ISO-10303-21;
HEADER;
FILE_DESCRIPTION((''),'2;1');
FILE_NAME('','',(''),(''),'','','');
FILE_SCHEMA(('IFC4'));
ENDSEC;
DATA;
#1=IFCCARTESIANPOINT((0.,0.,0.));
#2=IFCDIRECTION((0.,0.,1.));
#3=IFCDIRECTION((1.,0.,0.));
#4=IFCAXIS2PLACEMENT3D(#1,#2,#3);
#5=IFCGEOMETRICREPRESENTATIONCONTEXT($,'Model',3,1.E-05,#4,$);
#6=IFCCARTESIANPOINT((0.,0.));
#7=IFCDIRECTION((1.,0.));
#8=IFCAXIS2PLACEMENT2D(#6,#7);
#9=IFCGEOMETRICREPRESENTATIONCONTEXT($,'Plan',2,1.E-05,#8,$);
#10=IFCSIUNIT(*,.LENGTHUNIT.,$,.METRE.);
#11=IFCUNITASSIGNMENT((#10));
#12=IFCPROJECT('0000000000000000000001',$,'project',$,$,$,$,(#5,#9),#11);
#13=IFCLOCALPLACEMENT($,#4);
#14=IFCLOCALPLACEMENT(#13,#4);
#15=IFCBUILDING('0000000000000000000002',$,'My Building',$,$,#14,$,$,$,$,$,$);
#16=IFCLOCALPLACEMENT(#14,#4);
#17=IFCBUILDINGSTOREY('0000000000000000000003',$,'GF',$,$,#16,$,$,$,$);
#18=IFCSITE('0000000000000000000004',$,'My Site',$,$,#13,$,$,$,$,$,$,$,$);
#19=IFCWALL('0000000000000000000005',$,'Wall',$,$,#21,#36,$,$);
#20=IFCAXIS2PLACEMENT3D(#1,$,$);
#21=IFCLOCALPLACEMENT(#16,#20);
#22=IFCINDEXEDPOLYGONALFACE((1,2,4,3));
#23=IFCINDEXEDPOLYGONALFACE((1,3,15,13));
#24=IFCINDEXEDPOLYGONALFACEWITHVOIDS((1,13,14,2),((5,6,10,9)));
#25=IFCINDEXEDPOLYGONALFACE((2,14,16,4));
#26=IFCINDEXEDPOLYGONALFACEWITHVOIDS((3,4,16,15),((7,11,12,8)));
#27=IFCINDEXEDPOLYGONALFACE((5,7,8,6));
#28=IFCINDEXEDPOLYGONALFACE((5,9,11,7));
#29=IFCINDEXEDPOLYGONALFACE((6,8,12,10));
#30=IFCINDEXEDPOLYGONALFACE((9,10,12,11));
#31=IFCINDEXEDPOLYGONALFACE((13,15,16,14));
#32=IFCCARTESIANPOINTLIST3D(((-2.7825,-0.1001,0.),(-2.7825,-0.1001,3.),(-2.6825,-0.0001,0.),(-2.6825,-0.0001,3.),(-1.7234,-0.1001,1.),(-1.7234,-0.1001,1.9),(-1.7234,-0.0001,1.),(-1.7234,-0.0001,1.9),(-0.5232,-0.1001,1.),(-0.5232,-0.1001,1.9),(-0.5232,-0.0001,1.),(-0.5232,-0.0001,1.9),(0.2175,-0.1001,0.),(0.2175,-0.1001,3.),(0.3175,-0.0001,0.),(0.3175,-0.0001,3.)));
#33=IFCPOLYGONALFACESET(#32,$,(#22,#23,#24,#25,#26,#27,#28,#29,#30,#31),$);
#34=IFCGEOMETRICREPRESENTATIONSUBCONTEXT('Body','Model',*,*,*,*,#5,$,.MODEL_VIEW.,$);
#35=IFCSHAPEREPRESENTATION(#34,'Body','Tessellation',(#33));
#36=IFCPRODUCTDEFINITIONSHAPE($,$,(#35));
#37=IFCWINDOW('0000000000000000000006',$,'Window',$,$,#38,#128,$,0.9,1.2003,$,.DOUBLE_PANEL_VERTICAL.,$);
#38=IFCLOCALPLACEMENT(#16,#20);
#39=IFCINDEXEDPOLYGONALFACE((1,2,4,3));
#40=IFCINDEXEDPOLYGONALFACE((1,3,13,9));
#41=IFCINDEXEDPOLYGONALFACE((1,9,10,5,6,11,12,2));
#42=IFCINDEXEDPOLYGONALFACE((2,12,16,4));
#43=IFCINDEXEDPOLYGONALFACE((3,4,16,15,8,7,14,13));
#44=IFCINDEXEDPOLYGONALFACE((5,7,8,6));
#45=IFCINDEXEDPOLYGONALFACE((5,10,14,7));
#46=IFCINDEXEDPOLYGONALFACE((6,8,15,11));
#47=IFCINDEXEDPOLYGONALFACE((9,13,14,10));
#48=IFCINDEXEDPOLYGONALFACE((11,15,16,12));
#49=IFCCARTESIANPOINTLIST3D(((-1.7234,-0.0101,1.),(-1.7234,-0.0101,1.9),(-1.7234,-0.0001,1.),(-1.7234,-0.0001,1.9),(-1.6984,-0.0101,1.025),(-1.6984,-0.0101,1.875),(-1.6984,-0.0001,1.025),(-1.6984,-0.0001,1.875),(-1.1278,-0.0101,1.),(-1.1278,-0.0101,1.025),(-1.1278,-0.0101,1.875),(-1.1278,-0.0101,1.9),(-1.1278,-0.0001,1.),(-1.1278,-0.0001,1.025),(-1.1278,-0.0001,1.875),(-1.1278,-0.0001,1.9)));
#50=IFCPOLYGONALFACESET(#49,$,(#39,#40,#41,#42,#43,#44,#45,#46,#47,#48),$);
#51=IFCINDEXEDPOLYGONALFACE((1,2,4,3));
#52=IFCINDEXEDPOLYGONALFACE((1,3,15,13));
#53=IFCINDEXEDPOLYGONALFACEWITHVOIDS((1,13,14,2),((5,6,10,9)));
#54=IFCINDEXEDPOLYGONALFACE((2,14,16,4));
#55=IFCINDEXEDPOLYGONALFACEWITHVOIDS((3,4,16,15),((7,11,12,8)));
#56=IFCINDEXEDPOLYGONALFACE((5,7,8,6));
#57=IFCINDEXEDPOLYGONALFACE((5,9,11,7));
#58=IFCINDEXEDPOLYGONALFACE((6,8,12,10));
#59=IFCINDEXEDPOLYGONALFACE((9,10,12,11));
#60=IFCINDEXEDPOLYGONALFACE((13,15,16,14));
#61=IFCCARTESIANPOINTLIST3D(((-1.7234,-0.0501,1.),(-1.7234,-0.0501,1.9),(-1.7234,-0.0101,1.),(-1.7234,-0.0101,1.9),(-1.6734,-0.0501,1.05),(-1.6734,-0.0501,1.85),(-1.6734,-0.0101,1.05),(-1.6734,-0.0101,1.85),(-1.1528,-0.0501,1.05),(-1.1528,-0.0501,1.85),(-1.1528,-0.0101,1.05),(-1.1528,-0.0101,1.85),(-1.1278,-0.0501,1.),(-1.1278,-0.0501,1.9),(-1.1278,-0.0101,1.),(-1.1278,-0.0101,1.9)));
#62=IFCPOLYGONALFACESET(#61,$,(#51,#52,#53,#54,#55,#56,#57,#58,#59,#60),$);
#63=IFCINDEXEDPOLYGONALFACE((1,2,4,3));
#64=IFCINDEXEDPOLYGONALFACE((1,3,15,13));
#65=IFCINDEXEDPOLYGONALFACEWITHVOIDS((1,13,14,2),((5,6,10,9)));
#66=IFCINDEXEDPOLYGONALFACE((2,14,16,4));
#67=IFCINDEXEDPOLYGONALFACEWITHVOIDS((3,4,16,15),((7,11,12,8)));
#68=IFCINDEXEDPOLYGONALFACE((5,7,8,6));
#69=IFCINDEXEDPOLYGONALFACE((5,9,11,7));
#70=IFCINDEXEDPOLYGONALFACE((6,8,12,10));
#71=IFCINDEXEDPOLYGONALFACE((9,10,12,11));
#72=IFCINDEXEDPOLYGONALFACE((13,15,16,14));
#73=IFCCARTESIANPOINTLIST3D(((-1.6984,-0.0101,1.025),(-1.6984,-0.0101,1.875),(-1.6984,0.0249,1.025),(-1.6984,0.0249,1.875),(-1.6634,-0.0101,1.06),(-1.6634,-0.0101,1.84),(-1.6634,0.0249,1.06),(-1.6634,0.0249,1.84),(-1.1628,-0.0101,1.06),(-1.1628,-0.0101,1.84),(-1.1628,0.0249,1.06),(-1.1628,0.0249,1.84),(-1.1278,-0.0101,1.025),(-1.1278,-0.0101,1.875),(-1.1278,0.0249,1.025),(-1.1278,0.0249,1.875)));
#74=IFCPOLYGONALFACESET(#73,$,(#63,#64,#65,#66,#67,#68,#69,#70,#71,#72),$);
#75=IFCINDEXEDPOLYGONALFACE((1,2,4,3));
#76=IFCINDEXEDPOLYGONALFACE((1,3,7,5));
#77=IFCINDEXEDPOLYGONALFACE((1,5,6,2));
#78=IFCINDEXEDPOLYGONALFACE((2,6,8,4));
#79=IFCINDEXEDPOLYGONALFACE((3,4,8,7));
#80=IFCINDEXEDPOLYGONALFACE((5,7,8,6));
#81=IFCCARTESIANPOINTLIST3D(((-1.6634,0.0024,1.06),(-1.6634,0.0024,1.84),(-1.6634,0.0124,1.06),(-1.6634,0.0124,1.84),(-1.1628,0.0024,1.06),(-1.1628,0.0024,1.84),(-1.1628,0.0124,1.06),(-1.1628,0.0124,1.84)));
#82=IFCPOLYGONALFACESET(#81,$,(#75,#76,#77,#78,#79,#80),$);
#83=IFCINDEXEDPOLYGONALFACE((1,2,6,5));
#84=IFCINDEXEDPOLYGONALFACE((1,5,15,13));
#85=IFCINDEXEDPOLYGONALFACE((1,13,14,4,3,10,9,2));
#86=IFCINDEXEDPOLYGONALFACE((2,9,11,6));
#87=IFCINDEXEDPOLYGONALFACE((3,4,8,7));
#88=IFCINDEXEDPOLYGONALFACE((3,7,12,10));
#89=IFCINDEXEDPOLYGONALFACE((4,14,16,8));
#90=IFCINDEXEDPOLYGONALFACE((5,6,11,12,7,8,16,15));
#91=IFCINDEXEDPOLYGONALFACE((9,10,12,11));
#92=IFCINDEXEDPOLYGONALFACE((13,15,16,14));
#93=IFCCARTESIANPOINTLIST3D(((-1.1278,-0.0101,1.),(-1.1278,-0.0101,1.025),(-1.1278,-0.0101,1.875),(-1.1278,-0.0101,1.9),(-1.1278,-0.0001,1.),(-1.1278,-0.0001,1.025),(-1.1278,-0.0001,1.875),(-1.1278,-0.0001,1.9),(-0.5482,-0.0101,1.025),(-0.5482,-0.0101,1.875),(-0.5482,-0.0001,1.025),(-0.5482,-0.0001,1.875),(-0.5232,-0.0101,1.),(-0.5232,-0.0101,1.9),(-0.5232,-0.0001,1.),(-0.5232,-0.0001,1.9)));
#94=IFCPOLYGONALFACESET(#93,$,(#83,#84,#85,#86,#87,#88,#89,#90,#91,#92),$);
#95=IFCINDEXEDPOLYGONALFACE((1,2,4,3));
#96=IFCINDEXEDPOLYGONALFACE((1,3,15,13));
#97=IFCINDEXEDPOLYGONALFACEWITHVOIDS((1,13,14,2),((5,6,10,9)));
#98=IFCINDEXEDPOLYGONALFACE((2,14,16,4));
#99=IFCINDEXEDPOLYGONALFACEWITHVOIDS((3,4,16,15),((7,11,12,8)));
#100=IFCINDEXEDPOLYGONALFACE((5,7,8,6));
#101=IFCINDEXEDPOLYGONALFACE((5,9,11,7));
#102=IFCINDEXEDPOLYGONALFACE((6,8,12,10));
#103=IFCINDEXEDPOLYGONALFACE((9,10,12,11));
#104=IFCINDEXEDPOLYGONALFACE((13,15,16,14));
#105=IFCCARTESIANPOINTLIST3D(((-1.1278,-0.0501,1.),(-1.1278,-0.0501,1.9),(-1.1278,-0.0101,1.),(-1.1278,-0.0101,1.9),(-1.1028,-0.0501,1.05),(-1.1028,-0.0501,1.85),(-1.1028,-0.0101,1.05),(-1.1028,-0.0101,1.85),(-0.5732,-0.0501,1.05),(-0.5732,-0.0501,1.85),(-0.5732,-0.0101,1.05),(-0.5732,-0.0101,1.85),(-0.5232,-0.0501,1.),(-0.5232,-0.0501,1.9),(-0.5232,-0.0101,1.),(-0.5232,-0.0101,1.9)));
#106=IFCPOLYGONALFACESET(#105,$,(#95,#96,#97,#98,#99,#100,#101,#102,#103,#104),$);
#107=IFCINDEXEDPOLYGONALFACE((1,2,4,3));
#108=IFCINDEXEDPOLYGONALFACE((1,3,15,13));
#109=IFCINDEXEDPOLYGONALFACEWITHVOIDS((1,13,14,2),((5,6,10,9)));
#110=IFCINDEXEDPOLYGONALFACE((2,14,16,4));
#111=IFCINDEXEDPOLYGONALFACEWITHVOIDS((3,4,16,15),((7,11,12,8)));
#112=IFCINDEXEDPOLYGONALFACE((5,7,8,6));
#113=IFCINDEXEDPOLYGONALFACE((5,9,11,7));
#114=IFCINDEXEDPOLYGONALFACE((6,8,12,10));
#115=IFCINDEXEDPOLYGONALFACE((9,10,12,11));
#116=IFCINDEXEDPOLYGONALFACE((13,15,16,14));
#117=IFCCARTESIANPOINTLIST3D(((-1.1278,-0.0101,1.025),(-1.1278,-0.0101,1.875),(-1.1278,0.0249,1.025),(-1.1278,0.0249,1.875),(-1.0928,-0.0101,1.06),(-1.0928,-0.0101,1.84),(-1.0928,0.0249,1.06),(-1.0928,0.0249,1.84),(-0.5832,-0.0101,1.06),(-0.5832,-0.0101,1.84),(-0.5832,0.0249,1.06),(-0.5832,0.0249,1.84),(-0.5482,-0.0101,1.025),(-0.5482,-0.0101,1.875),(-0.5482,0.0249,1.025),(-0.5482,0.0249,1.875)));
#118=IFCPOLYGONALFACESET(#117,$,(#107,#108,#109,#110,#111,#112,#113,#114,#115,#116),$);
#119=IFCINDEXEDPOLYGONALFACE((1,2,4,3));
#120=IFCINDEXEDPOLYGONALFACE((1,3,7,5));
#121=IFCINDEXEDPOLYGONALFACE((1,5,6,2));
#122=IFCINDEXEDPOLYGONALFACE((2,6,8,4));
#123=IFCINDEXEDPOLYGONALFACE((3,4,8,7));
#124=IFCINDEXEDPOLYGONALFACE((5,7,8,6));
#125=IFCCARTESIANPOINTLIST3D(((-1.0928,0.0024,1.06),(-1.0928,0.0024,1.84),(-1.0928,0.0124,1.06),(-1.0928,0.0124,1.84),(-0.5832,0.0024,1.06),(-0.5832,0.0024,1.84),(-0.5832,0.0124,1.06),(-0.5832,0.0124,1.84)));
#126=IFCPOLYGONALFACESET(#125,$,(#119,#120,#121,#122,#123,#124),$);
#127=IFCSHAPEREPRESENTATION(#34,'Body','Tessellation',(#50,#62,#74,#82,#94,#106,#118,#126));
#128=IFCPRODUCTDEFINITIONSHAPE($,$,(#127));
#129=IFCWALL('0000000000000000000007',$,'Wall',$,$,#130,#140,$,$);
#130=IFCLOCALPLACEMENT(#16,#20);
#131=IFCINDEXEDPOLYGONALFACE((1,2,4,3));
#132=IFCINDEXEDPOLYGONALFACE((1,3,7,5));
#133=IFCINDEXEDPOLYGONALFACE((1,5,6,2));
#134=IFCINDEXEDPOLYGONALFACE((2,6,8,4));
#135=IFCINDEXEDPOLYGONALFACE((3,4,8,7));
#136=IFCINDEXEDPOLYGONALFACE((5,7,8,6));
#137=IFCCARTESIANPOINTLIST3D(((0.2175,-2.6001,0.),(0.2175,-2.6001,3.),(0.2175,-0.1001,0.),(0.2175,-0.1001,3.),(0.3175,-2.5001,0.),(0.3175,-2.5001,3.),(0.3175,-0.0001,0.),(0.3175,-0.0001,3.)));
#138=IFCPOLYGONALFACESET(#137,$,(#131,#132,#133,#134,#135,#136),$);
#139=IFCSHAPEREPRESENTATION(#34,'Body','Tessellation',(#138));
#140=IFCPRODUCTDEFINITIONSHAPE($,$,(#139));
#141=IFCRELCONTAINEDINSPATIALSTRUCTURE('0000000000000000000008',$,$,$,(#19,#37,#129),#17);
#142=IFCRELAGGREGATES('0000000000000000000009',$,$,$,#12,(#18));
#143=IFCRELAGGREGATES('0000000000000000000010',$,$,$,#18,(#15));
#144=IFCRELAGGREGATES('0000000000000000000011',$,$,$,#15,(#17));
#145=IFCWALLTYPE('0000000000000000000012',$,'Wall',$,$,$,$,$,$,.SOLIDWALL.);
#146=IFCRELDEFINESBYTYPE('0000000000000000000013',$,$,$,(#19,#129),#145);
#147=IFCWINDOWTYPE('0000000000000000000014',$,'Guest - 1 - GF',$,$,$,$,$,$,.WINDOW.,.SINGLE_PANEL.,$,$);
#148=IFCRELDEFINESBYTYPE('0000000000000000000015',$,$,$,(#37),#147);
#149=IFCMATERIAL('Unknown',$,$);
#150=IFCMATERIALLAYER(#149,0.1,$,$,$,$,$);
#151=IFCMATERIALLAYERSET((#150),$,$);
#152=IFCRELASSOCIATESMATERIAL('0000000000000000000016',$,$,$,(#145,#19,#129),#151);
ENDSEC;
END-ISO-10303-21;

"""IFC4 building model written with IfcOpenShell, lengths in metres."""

from ifc_helpers import new_model, entity, si_unit, frame, origin_with_axes, origin_2d_with_axis, place, context, subcontext, project, spatial, line, indexed_curve, outline, extrude, shape, source, transform, mapped, material, layer, layer_set, layer_usage, type_object, type_shapes, element, fill, save


model = new_model("IFC4")

# Units and contexts
model_context = context("Model", 3, precision=1e-05, world=origin_with_axes())
plan_context = context("Plan", 2, precision=1e-05, world=origin_2d_with_axis())
body_context_1 = subcontext(model_context, "Body", "Model", "MODEL_VIEW")
body_context_2 = subcontext(plan_context, "Body", "Plan", "PLAN_VIEW")
ifc_project = project(units=[si_unit("LENGTHUNIT", "METRE")], contexts=[model_context, plan_context])

# Site, building, storey
site_placement = place(None, origin_with_axes())
site = spatial("IfcSite", under=ifc_project, at=site_placement, Name="My Site")
building_placement = place(site_placement, origin_with_axes())
building = spatial("IfcBuilding", under=site, at=building_placement, Name="My Building")
storey_placement = place(building_placement, origin_with_axes())
storey = spatial("IfcBuildingStorey", under=building, at=storey_placement, Name="GF")

# Shared definitions
ifc_material = material(Name="Unknown")

# Shared definitions
ifc_layer_1 = layer(ifc_material, 0.1)
ifc_layer_set_1 = layer_set([ifc_layer_1])
wall_type = type_object("IfcWallType", Name="Wall", PredefinedType="SOLIDWALL", material=ifc_layer_set_1)

# Wall, opening, window
ifc_layer_usage_1 = layer_usage(ifc_layer_set_1, "AXIS2", "POSITIVE", 0.0)
wall_1_placement = place(storey_placement, frame((-2.7825, -0.1001, 0.0), z_axis=(0.0, 0.0, 1.0), x_axis=(1.0, 0.0, 0.0)))
wall_1 = element("IfcWall", 1, at=wall_1_placement, inside=storey, type_object=wall_type, material=ifc_layer_usage_1, Name="Wall", context=body_context_1, shape_type="SweptSolid", body=[
    extrude(outline(indexed_curve([(0.0, 0.0), (0.1, 0.1), (3.1, 0.1), (3.0, 0.0)], segments=[line(1, 2, 3, 4, 1)])), origin_with_axes(), (0.0, 0.0, 1.0), 3.0),
])
shared_shape_1 = source(origin_with_axes(), body_context_1, "Body", "SweptSolid", [
    extrude(outline(indexed_curve([(0.0, 0.0), (1.2003, 0.0), (1.2003, 0.9), (0.0, 0.9)], segments=[line(1, 2, 3, 4, 1)])), frame((0.0, -0.6, 0.0), z_axis=(0.0, -1.0, 0.0), x_axis=(1.0, 0.0, 0.0)), (0.0, 0.0, -1.0), 1.2),
])
opening_1_placement = place(wall_1_placement, frame((1.0591, 0.0, 1.0), z_axis=(0.0, 0.0, 1.0), x_axis=(1.0, 0.0, 0.0)))
opening_1 = element("IfcOpeningElement", 2, at=opening_1_placement, cuts=wall_1, PredefinedType="OPENING", context=body_context_1, shape_type="MappedRepresentation", body=[
    mapped(shared_shape_1, transform((0.0, 0.0, 0.0), x_axis=(1.0, 0.0, 0.0), y_axis=(0.0, 1.0, 0.0), z_axis=(0.0, 0.0, 1.0), scale=1.0)),
])
window_type_1 = type_object("IfcWindowType", Name="Guest - 1 - GF", PartitioningType="SINGLE_PANEL", PredefinedType="WINDOW")
shared_shape_2 = source(origin_with_axes(), body_context_1, "Body", "SweptSolid", [
    extrude(outline(indexed_curve([(0.5956, 0.0), (0.0, 0.0), (0.0, 0.9), (0.5956, 0.9), (0.5956, 0.875), (0.025, 0.875), (0.025, 0.025), (0.5956, 0.025)], segments=[line(1, 2, 3, 4, 5, 6, 7, 8, 1)])), frame((0.0, 0.09, 0.0), z_axis=(0.0, -1.0, 0.0), x_axis=(1.0, 0.0, 0.0)), (0.0, 0.0, -1.0), 0.01),
    extrude(outline(indexed_curve([(0.0, 0.0), (0.5956, 0.0), (0.5956, 0.9), (0.0, 0.9)], segments=[line(1, 2, 3, 4, 1)]), holes=[indexed_curve([(0.05, 0.05), (0.5706, 0.05), (0.5706, 0.85), (0.05, 0.85)], segments=[line(1, 2, 3, 4, 1)])]), frame((0.0, 0.05, 0.0), z_axis=(0.0, -1.0, 0.0), x_axis=(1.0, 0.0, 0.0)), (0.0, 0.0, -1.0), 0.04),
    extrude(outline(indexed_curve([(0.0, 0.0), (0.5706, 0.0), (0.5706, 0.85), (0.0, 0.85)], segments=[line(1, 2, 3, 4, 1)]), holes=[indexed_curve([(0.035, 0.035), (0.5356, 0.035), (0.5356, 0.815), (0.035, 0.815)], segments=[line(1, 2, 3, 4, 1)])]), frame((0.025, 0.09, 0.025), z_axis=(0.0, -1.0, 0.0), x_axis=(1.0, 0.0, 0.0)), (0.0, 0.0, -1.0), 0.035),
    extrude(outline(indexed_curve([(0.035, 0.035), (0.5356, 0.035), (0.5356, 0.815), (0.035, 0.815)], segments=[line(1, 2, 3, 4, 1)])), frame((0.025, 0.1025, 0.025), z_axis=(0.0, -1.0, 0.0), x_axis=(1.0, 0.0, 0.0)), (0.0, 0.0, -1.0), 0.01),
    extrude(outline(indexed_curve([(0.0, 0.9), (0.6046, 0.9), (0.6046, 0.0), (0.0, 0.0), (0.0, 0.025), (0.5796, 0.025), (0.5796, 0.875), (0.0, 0.875)], segments=[line(1, 2, 3, 4, 5, 6, 7, 8, 1)])), frame((0.5956, 0.09, 0.0), z_axis=(0.0, -1.0, 0.0), x_axis=(1.0, 0.0, 0.0)), (0.0, 0.0, -1.0), 0.01),
    extrude(outline(indexed_curve([(0.0, 0.0), (0.6046, 0.0), (0.6046, 0.9), (0.0, 0.9)], segments=[line(1, 2, 3, 4, 1)]), holes=[indexed_curve([(0.025, 0.05), (0.5546, 0.05), (0.5546, 0.85), (0.025, 0.85)], segments=[line(1, 2, 3, 4, 1)])]), frame((0.5956, 0.05, 0.0), z_axis=(0.0, -1.0, 0.0), x_axis=(1.0, 0.0, 0.0)), (0.0, 0.0, -1.0), 0.04),
    extrude(outline(indexed_curve([(0.0, 0.0), (0.5796, 0.0), (0.5796, 0.85), (0.0, 0.85)], segments=[line(1, 2, 3, 4, 1)]), holes=[indexed_curve([(0.035, 0.035), (0.5446, 0.035), (0.5446, 0.815), (0.035, 0.815)], segments=[line(1, 2, 3, 4, 1)])]), frame((0.5956, 0.09, 0.025), z_axis=(0.0, -1.0, 0.0), x_axis=(1.0, 0.0, 0.0)), (0.0, 0.0, -1.0), 0.035),
    extrude(outline(indexed_curve([(0.035, 0.035), (0.5446, 0.035), (0.5446, 0.815), (0.035, 0.815)], segments=[line(1, 2, 3, 4, 1)])), frame((0.5956, 0.1025, 0.025), z_axis=(0.0, -1.0, 0.0), x_axis=(1.0, 0.0, 0.0)), (0.0, 0.0, -1.0), 0.01),
])
shared_shape_3 = source(origin_with_axes(), body_context_2, "Body", "Curve2D", [
    entity("IfcIndexedPolyCurve", entity("IfcCartesianPointList2D", [[0.05, 0.05], [0.5706, 0.05]])),
    entity("IfcIndexedPolyCurve", entity("IfcCartesianPointList2D", [[0.0, 0.1], [0.025, 0.1], [0.025, 0.09], [0.05, 0.09], [0.05, 0.05], [0.0, 0.05]]), [entity("IfcLineIndex", [1, 2, 3, 4, 5, 6, 1])]),
    entity("IfcIndexedPolyCurve", entity("IfcCartesianPointList2D", [[0.5956, 0.1], [0.5956, 0.1], [0.5956, 0.09], [0.5706, 0.09], [0.5706, 0.05], [0.5956, 0.05]])),
    entity("IfcIndexedPolyCurve", entity("IfcCartesianPointList2D", [[0.025, 0.09], [0.06, 0.09], [0.06, 0.125], [0.025, 0.125]]), [entity("IfcLineIndex", [1, 2, 3, 4, 1])]),
    entity("IfcIndexedPolyCurve", entity("IfcCartesianPointList2D", [[0.5956, 0.09], [0.5606, 0.09], [0.5606, 0.125], [0.5956, 0.125]]), [entity("IfcLineIndex", [1, 2, 3, 4, 1])]),
    entity("IfcIndexedPolyCurve", entity("IfcCartesianPointList2D", [[0.06, 0.09], [0.5606, 0.09]])),
    entity("IfcIndexedPolyCurve", entity("IfcCartesianPointList2D", [[0.06, 0.125], [0.5606, 0.125]])),
    entity("IfcIndexedPolyCurve", entity("IfcCartesianPointList2D", [[0.06, 0.1075], [0.5606, 0.1075]])),
    entity("IfcIndexedPolyCurve", entity("IfcCartesianPointList2D", [[0.6206, 0.05], [1.1503, 0.05]])),
    entity("IfcIndexedPolyCurve", entity("IfcCartesianPointList2D", [[0.5956, 0.1], [0.5956, 0.1], [0.5956, 0.09], [0.6206, 0.09], [0.6206, 0.05], [0.5956, 0.05]])),
    entity("IfcIndexedPolyCurve", entity("IfcCartesianPointList2D", [[1.2003, 0.1], [1.1753, 0.1], [1.1753, 0.09], [1.1503, 0.09], [1.1503, 0.05], [1.2003, 0.05]]), [entity("IfcLineIndex", [1, 2, 3, 4, 5, 6, 1])]),
    entity("IfcIndexedPolyCurve", entity("IfcCartesianPointList2D", [[0.5956, 0.09], [0.6306, 0.09], [0.6306, 0.125], [0.5956, 0.125]]), [entity("IfcLineIndex", [1, 2, 3, 4, 1])]),
    entity("IfcIndexedPolyCurve", entity("IfcCartesianPointList2D", [[1.1753, 0.09], [1.1403, 0.09], [1.1403, 0.125], [1.1753, 0.125]]), [entity("IfcLineIndex", [1, 2, 3, 4, 1])]),
    entity("IfcIndexedPolyCurve", entity("IfcCartesianPointList2D", [[0.6306, 0.09], [1.1403, 0.09]])),
    entity("IfcIndexedPolyCurve", entity("IfcCartesianPointList2D", [[0.6306, 0.125], [1.1403, 0.125]])),
    entity("IfcIndexedPolyCurve", entity("IfcCartesianPointList2D", [[0.6306, 0.1075], [1.1403, 0.1075]])),
])
type_shapes(window_type_1, [shared_shape_2, shared_shape_3])
window_1_placement = place(opening_1_placement, frame((0.0, 0.0, 0.0), z_axis=(0.0, 0.0, 1.0), x_axis=(1.0, 0.0, 0.0)))
window_1 = element("IfcWindow", 3, at=window_1_placement, inside=storey, type_object=window_type_1, Name="Window", OverallHeight=0.9, OverallWidth=1.2003, PartitioningType="DOUBLE_PANEL_VERTICAL", shapes=[
    shape(body_context_1, "Body", "MappedRepresentation", [mapped(shared_shape_2, transform((0.0, 0.0, 0.0), x_axis=(1.0, 0.0, 0.0), y_axis=(0.0, 1.0, 0.0), z_axis=(0.0, 0.0, 1.0), scale=1.0))]),
    shape(body_context_2, "Body", "MappedRepresentation", [mapped(shared_shape_3, transform((0.0, 0.0, 0.0), x_axis=(1.0, 0.0, 0.0), y_axis=(0.0, 1.0, 0.0), z_axis=(0.0, 0.0, 1.0), scale=1.0))]),
])
fill(opening_1, window_1)

# Wall
ifc_layer_usage_2 = layer_usage(ifc_layer_set_1, "AXIS2", "POSITIVE", 0.0)
wall_2_placement = place(storey_placement, frame((0.2175, -0.1001, 0.0), z_axis=(0.0, 0.0, 1.0), x_axis=(0.0, -1.0, 0.0)))
element("IfcWall", 4, at=wall_2_placement, inside=storey, type_object=wall_type, material=ifc_layer_usage_2, Name="Wall", context=body_context_1, shape_type="SweptSolid", body=[
    extrude(outline(indexed_curve([(0.0, 0.0), (-0.1, 0.1), (2.4, 0.1), (2.5, 0.0)], segments=[line(1, 2, 3, 4, 1)])), origin_with_axes(), (0.0, 0.0, 1.0), 3.0),
])

save(model, "model.ifc")
